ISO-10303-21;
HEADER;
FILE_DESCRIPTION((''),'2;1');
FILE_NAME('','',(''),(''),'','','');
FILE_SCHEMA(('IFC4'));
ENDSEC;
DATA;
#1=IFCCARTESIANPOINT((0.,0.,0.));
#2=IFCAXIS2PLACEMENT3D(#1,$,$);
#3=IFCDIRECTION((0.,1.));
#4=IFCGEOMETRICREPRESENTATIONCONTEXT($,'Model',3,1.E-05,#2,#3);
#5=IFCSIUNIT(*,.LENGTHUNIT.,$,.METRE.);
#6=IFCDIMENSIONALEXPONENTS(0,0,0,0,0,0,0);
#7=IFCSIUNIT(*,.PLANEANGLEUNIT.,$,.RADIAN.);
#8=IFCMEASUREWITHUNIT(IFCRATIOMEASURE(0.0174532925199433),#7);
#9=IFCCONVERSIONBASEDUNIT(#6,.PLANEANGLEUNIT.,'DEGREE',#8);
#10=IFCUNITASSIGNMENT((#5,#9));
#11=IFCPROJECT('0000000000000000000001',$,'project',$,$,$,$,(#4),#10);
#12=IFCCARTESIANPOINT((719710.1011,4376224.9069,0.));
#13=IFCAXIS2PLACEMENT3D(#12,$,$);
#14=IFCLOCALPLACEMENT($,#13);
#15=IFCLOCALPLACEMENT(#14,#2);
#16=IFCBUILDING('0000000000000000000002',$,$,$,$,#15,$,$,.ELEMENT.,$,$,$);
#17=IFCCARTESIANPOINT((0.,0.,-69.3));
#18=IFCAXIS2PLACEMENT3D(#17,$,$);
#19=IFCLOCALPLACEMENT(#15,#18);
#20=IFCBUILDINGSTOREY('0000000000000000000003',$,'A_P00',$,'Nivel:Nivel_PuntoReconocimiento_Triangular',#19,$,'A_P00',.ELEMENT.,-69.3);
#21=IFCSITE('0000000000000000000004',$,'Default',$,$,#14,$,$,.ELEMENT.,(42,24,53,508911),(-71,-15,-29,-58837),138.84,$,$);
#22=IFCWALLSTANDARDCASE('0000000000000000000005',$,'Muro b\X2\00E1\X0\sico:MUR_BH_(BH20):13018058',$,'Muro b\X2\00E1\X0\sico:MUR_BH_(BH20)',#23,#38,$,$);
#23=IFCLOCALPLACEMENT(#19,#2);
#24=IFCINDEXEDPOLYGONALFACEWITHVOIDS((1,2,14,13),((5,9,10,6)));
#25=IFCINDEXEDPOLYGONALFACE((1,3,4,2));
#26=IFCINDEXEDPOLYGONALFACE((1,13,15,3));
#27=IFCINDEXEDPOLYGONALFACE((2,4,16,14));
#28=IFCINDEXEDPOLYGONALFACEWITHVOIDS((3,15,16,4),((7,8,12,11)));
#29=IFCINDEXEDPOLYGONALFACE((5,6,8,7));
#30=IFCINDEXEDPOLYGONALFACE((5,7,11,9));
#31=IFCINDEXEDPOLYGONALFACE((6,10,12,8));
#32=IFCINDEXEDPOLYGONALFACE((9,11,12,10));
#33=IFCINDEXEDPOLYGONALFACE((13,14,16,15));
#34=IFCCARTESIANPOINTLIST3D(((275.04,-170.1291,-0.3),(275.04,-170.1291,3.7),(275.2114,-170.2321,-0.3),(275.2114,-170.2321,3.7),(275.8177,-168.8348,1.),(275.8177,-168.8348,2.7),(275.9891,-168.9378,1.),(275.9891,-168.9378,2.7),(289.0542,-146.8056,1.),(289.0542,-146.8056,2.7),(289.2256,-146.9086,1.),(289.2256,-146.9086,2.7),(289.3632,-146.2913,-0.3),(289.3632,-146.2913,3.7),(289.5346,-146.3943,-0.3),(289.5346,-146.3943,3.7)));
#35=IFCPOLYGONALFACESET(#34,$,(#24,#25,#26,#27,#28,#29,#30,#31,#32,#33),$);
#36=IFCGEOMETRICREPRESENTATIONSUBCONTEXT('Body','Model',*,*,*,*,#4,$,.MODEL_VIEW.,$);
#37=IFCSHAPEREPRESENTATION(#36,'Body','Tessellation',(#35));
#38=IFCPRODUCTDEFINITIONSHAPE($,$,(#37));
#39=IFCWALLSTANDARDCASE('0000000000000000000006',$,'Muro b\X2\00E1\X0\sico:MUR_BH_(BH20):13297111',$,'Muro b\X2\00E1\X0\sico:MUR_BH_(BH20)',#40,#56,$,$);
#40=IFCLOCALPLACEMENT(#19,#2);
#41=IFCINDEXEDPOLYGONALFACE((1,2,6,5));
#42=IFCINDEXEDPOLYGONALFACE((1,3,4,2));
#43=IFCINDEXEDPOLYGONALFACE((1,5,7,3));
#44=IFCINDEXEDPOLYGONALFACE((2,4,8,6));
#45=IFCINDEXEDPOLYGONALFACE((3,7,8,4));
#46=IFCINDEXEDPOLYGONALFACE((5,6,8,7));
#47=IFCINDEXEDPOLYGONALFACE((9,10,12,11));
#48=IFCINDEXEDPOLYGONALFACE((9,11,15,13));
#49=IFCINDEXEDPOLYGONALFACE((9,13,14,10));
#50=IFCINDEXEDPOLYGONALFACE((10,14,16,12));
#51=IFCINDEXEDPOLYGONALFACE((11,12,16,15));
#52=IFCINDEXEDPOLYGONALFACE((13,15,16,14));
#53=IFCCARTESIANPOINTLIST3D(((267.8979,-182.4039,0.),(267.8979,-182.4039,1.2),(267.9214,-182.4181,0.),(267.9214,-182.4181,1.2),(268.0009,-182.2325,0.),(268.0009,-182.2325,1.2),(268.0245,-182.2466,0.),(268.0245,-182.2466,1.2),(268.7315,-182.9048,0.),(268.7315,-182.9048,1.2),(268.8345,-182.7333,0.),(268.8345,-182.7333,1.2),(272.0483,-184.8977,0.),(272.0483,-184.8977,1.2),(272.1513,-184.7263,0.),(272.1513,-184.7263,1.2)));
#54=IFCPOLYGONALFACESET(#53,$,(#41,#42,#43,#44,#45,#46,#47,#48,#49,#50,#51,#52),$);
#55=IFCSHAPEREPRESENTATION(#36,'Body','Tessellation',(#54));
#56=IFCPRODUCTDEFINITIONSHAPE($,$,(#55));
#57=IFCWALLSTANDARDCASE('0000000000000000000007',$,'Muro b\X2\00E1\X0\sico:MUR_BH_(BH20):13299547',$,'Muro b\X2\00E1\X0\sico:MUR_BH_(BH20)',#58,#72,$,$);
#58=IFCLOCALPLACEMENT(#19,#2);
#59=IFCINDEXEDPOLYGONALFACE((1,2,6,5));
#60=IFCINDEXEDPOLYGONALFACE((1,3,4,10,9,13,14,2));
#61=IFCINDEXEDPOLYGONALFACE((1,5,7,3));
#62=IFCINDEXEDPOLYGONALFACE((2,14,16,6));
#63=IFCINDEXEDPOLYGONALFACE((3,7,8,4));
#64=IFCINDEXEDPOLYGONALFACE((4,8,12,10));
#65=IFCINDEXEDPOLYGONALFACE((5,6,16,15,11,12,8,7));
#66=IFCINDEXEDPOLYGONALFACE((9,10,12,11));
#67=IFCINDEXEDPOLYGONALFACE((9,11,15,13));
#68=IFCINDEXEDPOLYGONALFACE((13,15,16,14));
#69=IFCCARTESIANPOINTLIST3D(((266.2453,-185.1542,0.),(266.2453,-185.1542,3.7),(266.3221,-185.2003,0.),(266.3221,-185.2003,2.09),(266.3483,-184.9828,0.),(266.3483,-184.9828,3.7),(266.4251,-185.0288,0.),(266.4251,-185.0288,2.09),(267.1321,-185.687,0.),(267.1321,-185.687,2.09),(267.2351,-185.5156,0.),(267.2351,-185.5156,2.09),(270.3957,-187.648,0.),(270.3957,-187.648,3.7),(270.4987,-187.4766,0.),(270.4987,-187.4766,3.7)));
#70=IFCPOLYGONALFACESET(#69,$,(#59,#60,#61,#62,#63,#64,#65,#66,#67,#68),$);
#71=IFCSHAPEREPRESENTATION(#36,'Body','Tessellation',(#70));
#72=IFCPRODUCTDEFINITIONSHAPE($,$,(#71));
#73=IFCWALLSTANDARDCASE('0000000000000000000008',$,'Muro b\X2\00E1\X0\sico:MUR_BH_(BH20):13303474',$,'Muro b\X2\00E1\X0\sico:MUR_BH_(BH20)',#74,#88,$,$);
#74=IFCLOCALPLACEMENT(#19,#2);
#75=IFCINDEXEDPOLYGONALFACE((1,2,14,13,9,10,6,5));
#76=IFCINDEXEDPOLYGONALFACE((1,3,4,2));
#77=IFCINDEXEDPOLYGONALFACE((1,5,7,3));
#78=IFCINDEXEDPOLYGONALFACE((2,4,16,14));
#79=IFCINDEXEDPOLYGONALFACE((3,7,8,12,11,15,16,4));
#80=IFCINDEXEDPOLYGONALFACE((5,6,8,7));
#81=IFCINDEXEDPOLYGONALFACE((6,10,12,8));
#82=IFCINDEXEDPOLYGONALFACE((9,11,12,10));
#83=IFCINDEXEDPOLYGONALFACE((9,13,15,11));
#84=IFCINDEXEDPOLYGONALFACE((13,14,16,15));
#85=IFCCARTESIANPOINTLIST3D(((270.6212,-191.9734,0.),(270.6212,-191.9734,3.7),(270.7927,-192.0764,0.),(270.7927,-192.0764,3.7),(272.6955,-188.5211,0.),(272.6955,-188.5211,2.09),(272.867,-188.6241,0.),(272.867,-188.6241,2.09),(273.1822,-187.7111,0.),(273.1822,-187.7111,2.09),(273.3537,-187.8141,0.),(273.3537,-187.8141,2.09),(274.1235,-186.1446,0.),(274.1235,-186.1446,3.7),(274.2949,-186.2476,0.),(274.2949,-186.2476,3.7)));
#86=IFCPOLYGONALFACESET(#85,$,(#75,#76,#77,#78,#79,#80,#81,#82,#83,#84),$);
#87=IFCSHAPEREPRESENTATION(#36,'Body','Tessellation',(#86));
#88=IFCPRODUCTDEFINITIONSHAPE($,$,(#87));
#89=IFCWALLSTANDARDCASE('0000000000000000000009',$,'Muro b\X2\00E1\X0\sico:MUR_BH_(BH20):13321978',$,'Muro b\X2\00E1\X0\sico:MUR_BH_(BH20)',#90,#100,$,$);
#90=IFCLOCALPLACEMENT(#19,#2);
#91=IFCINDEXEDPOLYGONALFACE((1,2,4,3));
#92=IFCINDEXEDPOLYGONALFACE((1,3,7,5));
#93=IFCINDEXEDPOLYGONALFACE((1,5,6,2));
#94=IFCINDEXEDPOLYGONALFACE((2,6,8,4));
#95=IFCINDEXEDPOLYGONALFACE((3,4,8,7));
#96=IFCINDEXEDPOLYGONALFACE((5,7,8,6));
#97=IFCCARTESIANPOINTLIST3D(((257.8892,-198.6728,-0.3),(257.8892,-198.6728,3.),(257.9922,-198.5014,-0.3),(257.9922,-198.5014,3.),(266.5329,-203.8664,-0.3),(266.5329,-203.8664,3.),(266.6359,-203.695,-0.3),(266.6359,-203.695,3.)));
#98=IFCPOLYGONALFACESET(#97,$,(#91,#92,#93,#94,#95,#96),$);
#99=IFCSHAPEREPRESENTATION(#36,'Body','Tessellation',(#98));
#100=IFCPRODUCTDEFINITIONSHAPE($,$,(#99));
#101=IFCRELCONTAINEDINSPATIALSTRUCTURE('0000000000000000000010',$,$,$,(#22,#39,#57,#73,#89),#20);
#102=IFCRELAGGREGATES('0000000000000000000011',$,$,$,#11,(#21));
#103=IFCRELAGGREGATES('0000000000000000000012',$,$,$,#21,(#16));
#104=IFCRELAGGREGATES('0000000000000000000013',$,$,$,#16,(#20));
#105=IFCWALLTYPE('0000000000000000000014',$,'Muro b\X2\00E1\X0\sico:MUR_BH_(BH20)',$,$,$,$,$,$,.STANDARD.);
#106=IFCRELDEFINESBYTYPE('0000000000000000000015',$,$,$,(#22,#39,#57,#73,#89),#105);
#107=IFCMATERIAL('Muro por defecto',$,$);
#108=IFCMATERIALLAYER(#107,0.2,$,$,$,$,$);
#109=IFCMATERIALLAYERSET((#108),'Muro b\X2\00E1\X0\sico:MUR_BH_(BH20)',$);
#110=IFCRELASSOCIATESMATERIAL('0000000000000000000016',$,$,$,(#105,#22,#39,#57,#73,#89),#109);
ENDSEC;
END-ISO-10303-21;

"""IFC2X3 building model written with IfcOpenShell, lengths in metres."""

from ifc_helpers import new_model, entity, si_unit, converted_unit, direction, frame, frame_2d, origin, origin_2d_with_axis, place, context, subcontext, project, spatial, rectangle, extrude, material, layer, layer_set, layer_usage, type_object, element, save


model = new_model("IFC2X3")

# Units and contexts
model_context = context("Model", 3, precision=1e-05, world=origin(), true_north=direction((0.0, 1.0)))
body_context = subcontext(model_context, "Body", "Model", "MODEL_VIEW")
ifc_project = project(units=[si_unit("LENGTHUNIT", "METRE"), converted_unit("PLANEANGLEUNIT", "DEGREE", entity("IfcRatioMeasure", 0.0174532925199433), si_unit("PLANEANGLEUNIT", "RADIAN"), dimensions=[0, 0, 0, 0, 0, 0, 0])], contexts=[model_context])

# Site, building, storey
site_placement = place(None, frame((719710.1011, 4376224.9069, 0.0)))
site = spatial("IfcSite", under=ifc_project, at=site_placement, Name="Default", CompositionType="ELEMENT", RefLatitude=(42, 24, 53, 508911), RefLongitude=(-71, -15, -29, -58837), RefElevation=138.84)
building_placement = place(site_placement, origin())
building = spatial("IfcBuilding", under=site, at=building_placement, CompositionType="ELEMENT")
storey_placement = place(building_placement, frame((0.0, 0.0, -69.3)))
storey = spatial("IfcBuildingStorey", under=building, at=storey_placement, Name="A_P00", ObjectType="Nivel:Nivel_PuntoReconocimiento_Triangular", LongName="A_P00", CompositionType="ELEMENT", Elevation=-69.3)

# Shared definitions
ifc_material_1 = material(Name="Muro por defecto")
ifc_layer_1 = layer(ifc_material_1, 0.2)
ifc_layer_set_1 = layer_set([ifc_layer_1], Name="Muro básico:MUR_BH_(BH20)")
wall_type_1 = type_object("IfcWallType", Name="Muro básico:MUR_BH_(BH20)", PredefinedType="STANDARD", material=ifc_layer_set_1)

# Walls, openings
ifc_layer_usage_1 = layer_usage(ifc_layer_set_1, "AXIS2", "NEGATIVE", 0.1)
wall_1_placement = place(storey_placement, frame((275.1257, -170.1806, -0.3), z_axis=(0.0, 0.0, 1.0), x_axis=(0.515038, 0.857167, 0.0)))
wall_1 = element("IfcWallStandardCase", 1, at=wall_1_placement, inside=storey, type_object=wall_type_1, material=ifc_layer_usage_1, Name="Muro básico:MUR_BH_(BH20):13018058", ObjectType="Muro básico:MUR_BH_(BH20)", context=body_context, shape_type="SweptSolid", body=[
    extrude(rectangle(XDim=27.81, YDim=0.2, at=frame_2d((13.905, 0.0), x_axis=(-1.0, 0.0))), origin(), (0.0, 0.0, 1.0), 4.0),
])
opening_1_placement = place(wall_1_placement, origin())
element("IfcOpeningElement", 2, at=opening_1_placement, cuts=wall_1, ObjectType="Opening", context=body_context, shape_type="SweptSolid", body=[
    extrude(rectangle(XDim=1.7, YDim=25.7, at=frame_2d((0.0, 0.0), x_axis=(0.0, 1.0))), frame((14.36, -0.2524, 2.15), z_axis=(0.0, 1.0, 0.0), x_axis=(-1.0, 0.0, 0.0)), (0.0, 0.0, 1.0), 0.5048),
])
ifc_layer_usage_2 = layer_usage(ifc_layer_set_1, "AXIS2", "NEGATIVE", 0.1)
wall_2_placement = place(storey_placement, frame((267.9494, -182.3182, 0.0), z_axis=(0.0, 0.0, 1.0), x_axis=(0.857167, -0.515038, 0.0)))
wall_2 = element("IfcWallStandardCase", 3, at=wall_2_placement, inside=storey, type_object=wall_type_1, material=ifc_layer_usage_2, Name="Muro básico:MUR_BH_(BH20):13297111", ObjectType="Muro básico:MUR_BH_(BH20)", context=body_context, shape_type="SweptSolid", body=[
    extrude(rectangle(XDim=4.842, YDim=0.2, at=frame_2d((2.421, 0.0), x_axis=(-1.0, 0.0))), origin(), (0.0, 0.0, 1.0), 1.2),
])
opening_2_placement = place(wall_2_placement, frame((-323.5782, 18.273, 0.0), z_axis=(0.0, 0.0, 1.0), x_axis=(0.857167, 0.515038, 0.0)))
element("IfcOpeningElement", 4, at=opening_2_placement, cuts=wall_2, ObjectType="Opening", context=body_context, shape_type="SweptSolid", body=[
    extrude(rectangle(XDim=2.09, YDim=0.945, at=frame_2d((0.0, 0.0), x_axis=(0.0, 1.0))), frame((268.3265, -182.6614, 1.045), z_axis=(0.515038, 0.857167, 0.0), x_axis=(0.857167, -0.515038, 0.0)), (0.0, 0.0, 1.0), 0.2),
])
ifc_layer_usage_3 = layer_usage(ifc_layer_set_1, "AXIS2", "NEGATIVE", 0.1)
wall_3_placement = place(storey_placement, frame((266.2968, -185.0685, 0.0), z_axis=(0.0, 0.0, 1.0), x_axis=(0.857167, -0.515038, 0.0)))
wall_3 = element("IfcWallStandardCase", 5, at=wall_3_placement, inside=storey, type_object=wall_type_1, material=ifc_layer_usage_3, Name="Muro básico:MUR_BH_(BH20):13299547", ObjectType="Muro básico:MUR_BH_(BH20)", context=body_context, shape_type="SweptSolid", body=[
    extrude(rectangle(XDim=4.842, YDim=0.2, at=frame_2d((2.421, 0.0), x_axis=(-1.0, 0.0))), origin(), (0.0, 0.0, 1.0), 3.7),
])
opening_3_placement = place(wall_3_placement, frame((-323.5782, 21.4816, 0.0), z_axis=(0.0, 0.0, 1.0), x_axis=(0.857167, 0.515038, 0.0)))
element("IfcOpeningElement", 6, at=opening_3_placement, cuts=wall_3, ObjectType="Opening", context=body_context, shape_type="SweptSolid", body=[
    extrude(rectangle(XDim=2.09, YDim=0.945, at=frame_2d((0.0, 0.0), x_axis=(0.0, 1.0))), frame((266.7271, -185.4436, 1.045), z_axis=(0.515038, 0.857167, 0.0), x_axis=(0.857167, -0.515038, 0.0)), (0.0, 0.0, 1.0), 0.2),
])
ifc_layer_usage_4 = layer_usage(ifc_layer_set_1, "AXIS2", "NEGATIVE", 0.1)
wall_4_placement = place(storey_placement, frame((274.2092, -186.1961, 0.0), z_axis=(0.0, 0.0, 1.0), x_axis=(-0.515038, -0.857167, 0.0)))
wall_4 = element("IfcWallStandardCase", 7, at=wall_4_placement, inside=storey, type_object=wall_type_1, material=ifc_layer_usage_4, Name="Muro básico:MUR_BH_(BH20):13303474", ObjectType="Muro básico:MUR_BH_(BH20)", context=body_context, shape_type="SweptSolid", body=[
    extrude(rectangle(XDim=6.8, YDim=0.2, at=frame_2d((3.4, 0.0), x_axis=(-1.0, 0.0))), origin(), (0.0, 0.0, 1.0), 3.7),
])
opening_4_placement = place(wall_4_placement, frame((-18.373, -330.9412, 0.0), z_axis=(0.0, 0.0, 1.0), x_axis=(-0.515038, 0.857167, 0.0)))
element("IfcOpeningElement", 8, at=opening_4_placement, cuts=wall_4, ObjectType="Opening", context=body_context, shape_type="SweptSolid", body=[
    extrude(rectangle(XDim=2.09, YDim=0.945, at=origin_2d_with_axis()), frame((272.9389, -188.1161, 1.045), z_axis=(0.857167, -0.515038, 0.0), x_axis=(0.0, 0.0, -1.0)), (0.0, 0.0, 1.0), 0.2),
])

# Wall
ifc_layer_usage_5 = layer_usage(ifc_layer_set_1, "AXIS2", "NEGATIVE", 0.1)
wall_5_placement = place(storey_placement, frame((266.5844, -203.7807, -0.3), z_axis=(0.0, 0.0, 1.0), x_axis=(-0.857167, 0.515038, 0.0)))
element("IfcWallStandardCase", 9, at=wall_5_placement, inside=storey, type_object=wall_type_1, material=ifc_layer_usage_5, Name="Muro básico:MUR_BH_(BH20):13321978", ObjectType="Muro básico:MUR_BH_(BH20)", context=body_context, shape_type="SweptSolid", body=[
    extrude(rectangle(XDim=10.084, YDim=0.2, at=frame_2d((5.042, 0.0), x_axis=(-1.0, 0.0))), origin(), (0.0, 0.0, 1.0), 3.3),
])

save(model, "model.ifc")
